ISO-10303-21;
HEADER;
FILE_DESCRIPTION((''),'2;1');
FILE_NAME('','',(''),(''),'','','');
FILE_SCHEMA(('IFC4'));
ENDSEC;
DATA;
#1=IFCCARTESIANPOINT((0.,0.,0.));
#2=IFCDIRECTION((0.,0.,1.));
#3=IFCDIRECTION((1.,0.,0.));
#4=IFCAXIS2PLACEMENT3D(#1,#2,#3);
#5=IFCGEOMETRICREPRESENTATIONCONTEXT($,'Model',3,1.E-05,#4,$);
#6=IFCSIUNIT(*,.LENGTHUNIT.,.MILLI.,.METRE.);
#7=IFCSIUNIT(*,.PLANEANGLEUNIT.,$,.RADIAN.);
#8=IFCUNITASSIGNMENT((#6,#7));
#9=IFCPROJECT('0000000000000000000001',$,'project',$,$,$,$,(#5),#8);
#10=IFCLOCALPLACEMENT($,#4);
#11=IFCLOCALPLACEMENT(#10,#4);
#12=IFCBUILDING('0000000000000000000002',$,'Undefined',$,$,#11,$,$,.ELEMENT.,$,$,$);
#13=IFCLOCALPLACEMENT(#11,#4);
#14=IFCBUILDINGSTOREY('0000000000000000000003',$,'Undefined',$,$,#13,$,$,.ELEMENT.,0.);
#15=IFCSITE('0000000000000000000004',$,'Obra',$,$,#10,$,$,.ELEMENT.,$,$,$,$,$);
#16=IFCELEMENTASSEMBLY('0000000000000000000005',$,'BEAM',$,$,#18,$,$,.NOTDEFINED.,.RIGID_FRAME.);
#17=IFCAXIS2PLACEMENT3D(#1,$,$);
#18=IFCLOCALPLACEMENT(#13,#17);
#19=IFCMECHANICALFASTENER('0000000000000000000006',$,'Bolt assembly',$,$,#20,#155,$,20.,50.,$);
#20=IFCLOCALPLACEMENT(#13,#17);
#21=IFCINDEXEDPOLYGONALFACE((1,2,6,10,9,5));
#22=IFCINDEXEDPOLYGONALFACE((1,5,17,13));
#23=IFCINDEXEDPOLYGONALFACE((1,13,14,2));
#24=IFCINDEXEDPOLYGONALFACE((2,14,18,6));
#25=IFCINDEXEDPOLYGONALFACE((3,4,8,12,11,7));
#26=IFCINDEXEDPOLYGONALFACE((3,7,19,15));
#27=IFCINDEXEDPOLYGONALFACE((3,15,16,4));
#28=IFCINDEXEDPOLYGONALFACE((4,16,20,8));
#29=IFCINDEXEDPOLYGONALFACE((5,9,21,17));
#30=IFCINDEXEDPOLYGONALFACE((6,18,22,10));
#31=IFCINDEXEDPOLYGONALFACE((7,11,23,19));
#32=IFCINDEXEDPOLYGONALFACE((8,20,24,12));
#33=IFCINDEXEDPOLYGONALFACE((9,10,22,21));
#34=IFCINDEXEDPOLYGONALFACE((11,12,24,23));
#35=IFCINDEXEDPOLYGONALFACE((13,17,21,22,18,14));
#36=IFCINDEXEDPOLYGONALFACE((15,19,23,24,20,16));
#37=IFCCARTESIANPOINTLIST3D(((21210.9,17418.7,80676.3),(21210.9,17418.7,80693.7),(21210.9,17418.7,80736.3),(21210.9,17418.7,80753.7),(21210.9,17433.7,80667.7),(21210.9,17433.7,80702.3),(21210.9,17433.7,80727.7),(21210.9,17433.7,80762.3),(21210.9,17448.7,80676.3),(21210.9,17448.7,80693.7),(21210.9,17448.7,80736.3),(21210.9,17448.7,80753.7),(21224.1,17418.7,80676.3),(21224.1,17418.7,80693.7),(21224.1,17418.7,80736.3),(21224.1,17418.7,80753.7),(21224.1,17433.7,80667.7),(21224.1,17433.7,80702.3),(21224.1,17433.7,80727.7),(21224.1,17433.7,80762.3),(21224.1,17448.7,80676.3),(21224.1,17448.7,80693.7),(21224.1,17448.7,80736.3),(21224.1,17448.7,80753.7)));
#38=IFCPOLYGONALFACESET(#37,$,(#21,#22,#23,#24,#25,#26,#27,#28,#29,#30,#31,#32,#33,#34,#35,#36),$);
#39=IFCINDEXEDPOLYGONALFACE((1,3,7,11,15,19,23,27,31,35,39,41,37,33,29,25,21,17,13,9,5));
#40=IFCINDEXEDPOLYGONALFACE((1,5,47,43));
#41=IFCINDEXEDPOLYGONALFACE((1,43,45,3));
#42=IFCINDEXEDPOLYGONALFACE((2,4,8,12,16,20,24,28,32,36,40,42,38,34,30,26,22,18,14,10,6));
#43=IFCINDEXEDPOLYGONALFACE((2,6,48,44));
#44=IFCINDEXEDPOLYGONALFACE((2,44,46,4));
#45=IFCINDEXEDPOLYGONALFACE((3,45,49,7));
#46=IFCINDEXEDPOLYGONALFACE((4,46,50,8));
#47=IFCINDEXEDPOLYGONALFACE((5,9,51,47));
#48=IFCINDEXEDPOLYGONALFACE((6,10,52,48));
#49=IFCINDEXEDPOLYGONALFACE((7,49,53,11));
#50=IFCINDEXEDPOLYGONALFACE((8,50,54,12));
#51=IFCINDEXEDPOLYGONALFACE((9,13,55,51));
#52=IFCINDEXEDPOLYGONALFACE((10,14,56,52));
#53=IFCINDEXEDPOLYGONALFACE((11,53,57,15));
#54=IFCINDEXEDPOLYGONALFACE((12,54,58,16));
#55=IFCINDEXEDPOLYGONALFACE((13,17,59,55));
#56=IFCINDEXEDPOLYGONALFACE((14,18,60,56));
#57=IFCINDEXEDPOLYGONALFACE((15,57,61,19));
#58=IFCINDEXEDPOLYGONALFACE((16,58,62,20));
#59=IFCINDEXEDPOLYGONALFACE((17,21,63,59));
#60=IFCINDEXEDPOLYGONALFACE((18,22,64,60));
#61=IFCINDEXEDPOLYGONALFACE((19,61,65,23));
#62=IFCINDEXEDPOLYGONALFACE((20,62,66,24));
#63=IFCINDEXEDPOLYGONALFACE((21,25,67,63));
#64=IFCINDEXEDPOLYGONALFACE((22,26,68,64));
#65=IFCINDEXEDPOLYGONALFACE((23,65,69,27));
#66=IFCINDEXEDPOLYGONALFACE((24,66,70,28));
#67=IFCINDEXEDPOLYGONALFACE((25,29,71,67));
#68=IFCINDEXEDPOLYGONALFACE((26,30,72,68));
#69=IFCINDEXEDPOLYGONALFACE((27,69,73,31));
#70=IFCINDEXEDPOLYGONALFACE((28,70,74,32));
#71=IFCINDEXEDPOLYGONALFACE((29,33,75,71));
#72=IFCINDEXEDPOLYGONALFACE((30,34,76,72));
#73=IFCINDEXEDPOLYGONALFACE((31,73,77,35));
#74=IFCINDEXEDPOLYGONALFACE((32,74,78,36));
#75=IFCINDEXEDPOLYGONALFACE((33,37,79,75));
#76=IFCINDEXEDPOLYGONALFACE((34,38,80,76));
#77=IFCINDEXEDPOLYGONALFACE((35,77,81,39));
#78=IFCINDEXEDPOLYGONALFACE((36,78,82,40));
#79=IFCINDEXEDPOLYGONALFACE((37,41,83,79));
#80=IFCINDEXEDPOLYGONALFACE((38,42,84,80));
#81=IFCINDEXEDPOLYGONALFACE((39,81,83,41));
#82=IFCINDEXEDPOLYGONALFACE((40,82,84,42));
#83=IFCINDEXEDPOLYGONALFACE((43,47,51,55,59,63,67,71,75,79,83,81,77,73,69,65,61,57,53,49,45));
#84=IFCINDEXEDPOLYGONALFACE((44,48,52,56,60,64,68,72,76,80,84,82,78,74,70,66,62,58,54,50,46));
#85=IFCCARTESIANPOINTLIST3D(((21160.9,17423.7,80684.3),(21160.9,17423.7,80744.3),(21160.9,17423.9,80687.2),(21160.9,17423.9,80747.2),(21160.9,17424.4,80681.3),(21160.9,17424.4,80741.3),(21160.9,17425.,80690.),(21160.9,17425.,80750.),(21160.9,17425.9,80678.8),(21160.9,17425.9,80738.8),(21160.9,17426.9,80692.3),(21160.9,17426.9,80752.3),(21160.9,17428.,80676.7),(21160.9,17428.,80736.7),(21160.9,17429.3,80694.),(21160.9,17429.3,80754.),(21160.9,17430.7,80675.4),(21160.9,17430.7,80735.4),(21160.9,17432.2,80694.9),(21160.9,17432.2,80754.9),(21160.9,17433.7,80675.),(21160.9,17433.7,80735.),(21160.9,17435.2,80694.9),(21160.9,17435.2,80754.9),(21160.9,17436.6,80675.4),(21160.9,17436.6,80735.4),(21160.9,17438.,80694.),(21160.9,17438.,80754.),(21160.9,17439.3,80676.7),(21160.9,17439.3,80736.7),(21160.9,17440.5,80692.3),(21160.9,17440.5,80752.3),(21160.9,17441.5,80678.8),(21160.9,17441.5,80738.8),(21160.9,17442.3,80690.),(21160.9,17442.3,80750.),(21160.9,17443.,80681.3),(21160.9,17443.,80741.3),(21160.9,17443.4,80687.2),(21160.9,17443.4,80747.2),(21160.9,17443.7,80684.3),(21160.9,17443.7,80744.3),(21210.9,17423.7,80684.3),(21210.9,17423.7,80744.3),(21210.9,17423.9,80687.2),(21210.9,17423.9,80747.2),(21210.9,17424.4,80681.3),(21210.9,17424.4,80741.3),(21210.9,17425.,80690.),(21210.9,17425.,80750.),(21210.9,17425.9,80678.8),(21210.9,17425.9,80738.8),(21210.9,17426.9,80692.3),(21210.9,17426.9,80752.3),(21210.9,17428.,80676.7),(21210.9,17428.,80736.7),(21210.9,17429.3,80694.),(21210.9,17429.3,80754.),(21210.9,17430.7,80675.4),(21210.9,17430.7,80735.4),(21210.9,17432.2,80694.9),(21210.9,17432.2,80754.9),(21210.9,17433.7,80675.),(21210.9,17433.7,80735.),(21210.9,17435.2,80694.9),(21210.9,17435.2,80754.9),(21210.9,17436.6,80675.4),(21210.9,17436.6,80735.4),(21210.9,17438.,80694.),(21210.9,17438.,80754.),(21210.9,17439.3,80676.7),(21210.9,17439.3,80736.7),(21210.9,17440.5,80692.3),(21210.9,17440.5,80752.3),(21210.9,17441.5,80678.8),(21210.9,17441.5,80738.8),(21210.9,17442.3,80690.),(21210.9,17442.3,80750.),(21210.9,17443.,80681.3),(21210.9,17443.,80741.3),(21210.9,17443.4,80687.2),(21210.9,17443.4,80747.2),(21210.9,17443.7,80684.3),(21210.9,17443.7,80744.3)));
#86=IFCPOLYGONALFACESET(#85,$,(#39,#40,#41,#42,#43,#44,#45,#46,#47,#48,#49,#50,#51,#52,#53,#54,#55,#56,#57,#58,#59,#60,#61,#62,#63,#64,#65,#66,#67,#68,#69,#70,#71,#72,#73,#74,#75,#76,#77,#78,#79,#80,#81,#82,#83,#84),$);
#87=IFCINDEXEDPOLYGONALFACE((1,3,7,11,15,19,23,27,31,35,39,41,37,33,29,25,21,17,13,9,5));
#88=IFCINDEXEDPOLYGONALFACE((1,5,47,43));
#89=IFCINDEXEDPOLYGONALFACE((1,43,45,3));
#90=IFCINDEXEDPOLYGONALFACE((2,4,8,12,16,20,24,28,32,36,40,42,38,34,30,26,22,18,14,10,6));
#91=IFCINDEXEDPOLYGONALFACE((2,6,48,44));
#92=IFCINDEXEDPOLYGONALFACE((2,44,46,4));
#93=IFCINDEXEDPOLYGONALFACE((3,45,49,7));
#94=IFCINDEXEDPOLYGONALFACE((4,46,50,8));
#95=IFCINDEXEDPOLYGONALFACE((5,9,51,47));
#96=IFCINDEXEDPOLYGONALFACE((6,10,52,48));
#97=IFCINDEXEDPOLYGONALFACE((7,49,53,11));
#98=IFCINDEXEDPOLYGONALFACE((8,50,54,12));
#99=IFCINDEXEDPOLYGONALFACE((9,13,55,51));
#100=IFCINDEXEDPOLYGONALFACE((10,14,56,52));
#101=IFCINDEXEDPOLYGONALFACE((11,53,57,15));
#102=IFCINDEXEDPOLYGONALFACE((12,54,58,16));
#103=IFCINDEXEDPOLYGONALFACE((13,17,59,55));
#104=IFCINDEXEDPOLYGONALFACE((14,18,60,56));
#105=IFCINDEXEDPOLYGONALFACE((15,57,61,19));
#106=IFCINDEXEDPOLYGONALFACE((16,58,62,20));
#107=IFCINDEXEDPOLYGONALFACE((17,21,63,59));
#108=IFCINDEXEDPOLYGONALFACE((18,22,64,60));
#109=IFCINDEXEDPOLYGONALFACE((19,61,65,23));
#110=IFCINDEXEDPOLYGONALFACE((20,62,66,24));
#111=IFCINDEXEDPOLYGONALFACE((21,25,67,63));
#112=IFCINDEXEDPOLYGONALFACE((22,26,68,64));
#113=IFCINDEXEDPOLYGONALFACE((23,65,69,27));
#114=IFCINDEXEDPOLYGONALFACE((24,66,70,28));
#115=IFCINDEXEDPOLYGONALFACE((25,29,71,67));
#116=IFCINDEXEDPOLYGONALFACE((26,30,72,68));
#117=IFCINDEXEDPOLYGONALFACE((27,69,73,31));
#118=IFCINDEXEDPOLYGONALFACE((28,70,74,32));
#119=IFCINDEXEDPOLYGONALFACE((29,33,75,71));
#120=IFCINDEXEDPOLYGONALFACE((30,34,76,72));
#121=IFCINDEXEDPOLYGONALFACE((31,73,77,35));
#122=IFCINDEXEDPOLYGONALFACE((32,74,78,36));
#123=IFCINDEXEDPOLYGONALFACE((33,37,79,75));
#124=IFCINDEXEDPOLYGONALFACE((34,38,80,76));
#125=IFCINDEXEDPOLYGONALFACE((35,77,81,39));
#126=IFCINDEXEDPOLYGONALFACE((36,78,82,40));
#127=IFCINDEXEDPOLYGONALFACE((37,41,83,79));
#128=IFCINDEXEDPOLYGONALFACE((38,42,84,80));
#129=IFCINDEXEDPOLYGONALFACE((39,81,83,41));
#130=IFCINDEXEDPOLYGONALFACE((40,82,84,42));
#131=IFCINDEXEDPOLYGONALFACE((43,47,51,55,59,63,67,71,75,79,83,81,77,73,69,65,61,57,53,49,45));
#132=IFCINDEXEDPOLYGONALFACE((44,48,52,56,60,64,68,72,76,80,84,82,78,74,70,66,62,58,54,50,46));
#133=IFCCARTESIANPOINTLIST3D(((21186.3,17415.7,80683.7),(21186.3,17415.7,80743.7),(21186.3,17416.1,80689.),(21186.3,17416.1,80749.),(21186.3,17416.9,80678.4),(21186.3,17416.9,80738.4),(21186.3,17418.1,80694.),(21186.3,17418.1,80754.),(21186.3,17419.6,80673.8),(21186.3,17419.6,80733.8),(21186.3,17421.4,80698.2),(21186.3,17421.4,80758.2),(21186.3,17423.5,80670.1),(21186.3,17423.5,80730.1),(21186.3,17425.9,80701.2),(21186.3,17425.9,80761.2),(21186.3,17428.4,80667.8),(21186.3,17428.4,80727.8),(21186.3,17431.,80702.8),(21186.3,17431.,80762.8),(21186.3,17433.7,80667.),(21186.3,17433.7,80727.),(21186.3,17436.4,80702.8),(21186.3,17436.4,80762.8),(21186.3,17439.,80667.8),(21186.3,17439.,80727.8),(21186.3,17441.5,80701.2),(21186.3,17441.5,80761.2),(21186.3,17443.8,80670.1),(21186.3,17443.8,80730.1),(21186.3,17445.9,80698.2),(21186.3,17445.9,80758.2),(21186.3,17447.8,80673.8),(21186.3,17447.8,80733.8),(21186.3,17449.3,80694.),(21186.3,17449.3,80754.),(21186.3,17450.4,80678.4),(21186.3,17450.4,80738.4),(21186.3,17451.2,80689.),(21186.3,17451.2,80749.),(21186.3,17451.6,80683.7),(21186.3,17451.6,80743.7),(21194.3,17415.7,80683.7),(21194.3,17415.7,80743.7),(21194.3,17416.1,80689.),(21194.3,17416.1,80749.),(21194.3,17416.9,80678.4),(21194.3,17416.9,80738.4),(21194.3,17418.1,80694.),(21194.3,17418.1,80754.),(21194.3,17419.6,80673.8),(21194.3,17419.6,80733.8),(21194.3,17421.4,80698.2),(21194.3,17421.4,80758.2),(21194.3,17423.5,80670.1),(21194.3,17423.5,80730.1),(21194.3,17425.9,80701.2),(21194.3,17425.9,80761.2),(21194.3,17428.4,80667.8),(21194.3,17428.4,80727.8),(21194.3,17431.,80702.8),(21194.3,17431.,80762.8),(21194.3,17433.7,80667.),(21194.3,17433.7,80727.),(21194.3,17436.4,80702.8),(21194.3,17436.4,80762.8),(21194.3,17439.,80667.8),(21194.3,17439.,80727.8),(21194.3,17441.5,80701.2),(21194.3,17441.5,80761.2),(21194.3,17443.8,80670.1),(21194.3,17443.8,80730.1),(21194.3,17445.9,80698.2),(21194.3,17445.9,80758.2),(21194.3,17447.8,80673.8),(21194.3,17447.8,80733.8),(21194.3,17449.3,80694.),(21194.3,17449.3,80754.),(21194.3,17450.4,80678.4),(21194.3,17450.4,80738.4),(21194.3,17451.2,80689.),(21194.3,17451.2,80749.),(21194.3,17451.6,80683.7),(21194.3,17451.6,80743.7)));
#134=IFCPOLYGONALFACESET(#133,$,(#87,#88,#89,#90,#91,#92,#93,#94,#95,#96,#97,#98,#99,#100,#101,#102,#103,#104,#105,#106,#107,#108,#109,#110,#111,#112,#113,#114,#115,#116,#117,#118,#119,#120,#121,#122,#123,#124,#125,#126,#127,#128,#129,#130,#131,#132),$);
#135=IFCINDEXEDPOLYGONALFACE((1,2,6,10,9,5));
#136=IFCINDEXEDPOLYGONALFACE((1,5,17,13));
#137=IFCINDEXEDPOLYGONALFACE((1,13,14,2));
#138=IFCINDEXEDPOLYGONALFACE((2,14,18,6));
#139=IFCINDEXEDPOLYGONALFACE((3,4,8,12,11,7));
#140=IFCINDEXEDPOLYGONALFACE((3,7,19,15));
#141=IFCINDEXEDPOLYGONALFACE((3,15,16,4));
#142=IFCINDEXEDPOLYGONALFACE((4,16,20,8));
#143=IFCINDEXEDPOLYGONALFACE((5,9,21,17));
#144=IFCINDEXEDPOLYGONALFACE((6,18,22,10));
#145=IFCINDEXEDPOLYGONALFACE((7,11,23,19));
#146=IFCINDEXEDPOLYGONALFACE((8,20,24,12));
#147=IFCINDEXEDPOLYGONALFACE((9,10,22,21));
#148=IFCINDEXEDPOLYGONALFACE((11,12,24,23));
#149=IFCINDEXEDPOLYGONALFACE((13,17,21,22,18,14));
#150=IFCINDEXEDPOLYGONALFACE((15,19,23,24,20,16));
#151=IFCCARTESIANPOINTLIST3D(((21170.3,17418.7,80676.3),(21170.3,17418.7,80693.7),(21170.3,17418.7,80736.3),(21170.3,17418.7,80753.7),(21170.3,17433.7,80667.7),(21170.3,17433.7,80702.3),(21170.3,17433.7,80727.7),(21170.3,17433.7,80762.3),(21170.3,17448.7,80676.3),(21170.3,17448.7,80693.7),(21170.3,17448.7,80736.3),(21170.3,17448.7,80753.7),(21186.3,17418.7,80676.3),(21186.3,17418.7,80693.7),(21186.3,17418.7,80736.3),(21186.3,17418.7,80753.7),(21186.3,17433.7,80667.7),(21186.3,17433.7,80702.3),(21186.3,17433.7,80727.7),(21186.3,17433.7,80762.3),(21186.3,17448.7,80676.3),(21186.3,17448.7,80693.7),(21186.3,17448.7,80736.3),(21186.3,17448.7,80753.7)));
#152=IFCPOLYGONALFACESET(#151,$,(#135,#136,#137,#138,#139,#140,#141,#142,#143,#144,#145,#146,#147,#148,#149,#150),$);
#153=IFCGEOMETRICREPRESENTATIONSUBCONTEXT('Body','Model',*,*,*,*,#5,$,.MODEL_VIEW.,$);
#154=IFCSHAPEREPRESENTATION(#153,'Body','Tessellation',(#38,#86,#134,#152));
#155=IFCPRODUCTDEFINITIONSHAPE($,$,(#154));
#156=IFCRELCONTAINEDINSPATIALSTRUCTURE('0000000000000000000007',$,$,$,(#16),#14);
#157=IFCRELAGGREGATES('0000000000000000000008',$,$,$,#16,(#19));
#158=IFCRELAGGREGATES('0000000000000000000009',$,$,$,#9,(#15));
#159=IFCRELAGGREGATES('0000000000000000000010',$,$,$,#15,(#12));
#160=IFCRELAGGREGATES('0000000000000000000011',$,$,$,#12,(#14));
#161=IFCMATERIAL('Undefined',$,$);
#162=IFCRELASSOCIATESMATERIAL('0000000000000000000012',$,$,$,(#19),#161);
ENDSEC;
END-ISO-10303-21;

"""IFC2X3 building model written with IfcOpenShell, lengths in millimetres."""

from ifc_helpers import new_model, si_unit, frame, origin_with_axes, origin_2d_with_axis, place, context, subcontext, project, spatial, polyline, circle, outline, extrude, source, transform, mapped, material, element, aggregate, save


model = new_model("IFC2X3")

# Units and contexts
model_context = context("Model", 3, precision=1e-05, world=origin_with_axes())
body_context = subcontext(model_context, "Body", "Model", "MODEL_VIEW")
ifc_project = project(units=[si_unit("LENGTHUNIT", "METRE", prefix="MILLI"), si_unit("PLANEANGLEUNIT", "RADIAN")], contexts=[model_context])

# Site, building, storey
site_placement = place(None, origin_with_axes())
site = spatial("IfcSite", under=ifc_project, at=site_placement, Name="Obra", CompositionType="ELEMENT")
building_placement = place(site_placement, origin_with_axes())
building = spatial("IfcBuilding", under=site, at=building_placement, Name="Undefined", CompositionType="ELEMENT")
storey_placement = place(building_placement, origin_with_axes())
storey = spatial("IfcBuildingStorey", under=building, at=storey_placement, Name="Undefined", CompositionType="ELEMENT", Elevation=0.0)

# Shared definitions
ifc_material_1 = material(Name="Undefined")

# Element assembly, mechanical fastener
assembly_1_placement = place(storey_placement, origin_with_axes())
assembly_1 = element("IfcElementAssembly", 1, at=assembly_1_placement, inside=storey, Name="BEAM", AssemblyPlace="NOTDEFINED", PredefinedType="RIGID_FRAME")
shared_shape_1 = source(origin_with_axes(), body_context, "Body", "SweptSolid", [
    extrude(outline(polyline([(17.3, 0.0), (8.7, 15.0), (-8.7, 15.0), (-17.3, 0.0), (-8.7, -15.0), (8.7, -15.0), (17.3, 0.0)])), frame((0.0, -26.5, 0.0), z_axis=(0.0, 1.0, 0.0), x_axis=(1.0, 0.0, 0.0)), (0.0, 0.0, 1.0), 13.2),
    extrude(circle(Radius=10.0, at=origin_2d_with_axis()), frame((0.0, -13.3, 0.0), z_axis=(0.0, 1.0, 0.0), x_axis=(1.0, 0.0, 0.0)), (0.0, 0.0, 1.0), 50.0),
    extrude(circle(Radius=18.0, at=origin_2d_with_axis()), frame((0.0, 3.3, 0.0), z_axis=(0.0, 1.0, 0.0), x_axis=(1.0, 0.0, 0.0)), (0.0, 0.0, 1.0), 8.0),
    extrude(outline(polyline([(17.3, 0.0), (8.7, 15.0), (-8.7, 15.0), (-17.3, 0.0), (-8.7, -15.0), (8.7, -15.0), (17.3, 0.0)])), frame((0.0, 11.3, 0.0), z_axis=(0.0, 1.0, 0.0), x_axis=(1.0, 0.0, 0.0)), (0.0, 0.0, 1.0), 16.0),
])
mechanical_fastener_1_placement = place(assembly_1_placement, frame((21197.6, 17393.7, 80850.0), z_axis=(0.0, 1.0, 0.0), x_axis=(0.0, 0.0, -1.0)))
mechanical_fastener_1 = element("IfcMechanicalFastener", 2, at=mechanical_fastener_1_placement, material=ifc_material_1, Name="Bolt assembly", NominalDiameter=20.0, NominalLength=50.0, context=body_context, shape_type="MappedRepresentation", body=[
    mapped(shared_shape_1, transform((105.0, 0.0, 40.0))),
    mapped(shared_shape_1, transform((165.0, 0.0, 40.0))),
])
aggregate(assembly_1, [mechanical_fastener_1])

save(model, "model.ifc")
